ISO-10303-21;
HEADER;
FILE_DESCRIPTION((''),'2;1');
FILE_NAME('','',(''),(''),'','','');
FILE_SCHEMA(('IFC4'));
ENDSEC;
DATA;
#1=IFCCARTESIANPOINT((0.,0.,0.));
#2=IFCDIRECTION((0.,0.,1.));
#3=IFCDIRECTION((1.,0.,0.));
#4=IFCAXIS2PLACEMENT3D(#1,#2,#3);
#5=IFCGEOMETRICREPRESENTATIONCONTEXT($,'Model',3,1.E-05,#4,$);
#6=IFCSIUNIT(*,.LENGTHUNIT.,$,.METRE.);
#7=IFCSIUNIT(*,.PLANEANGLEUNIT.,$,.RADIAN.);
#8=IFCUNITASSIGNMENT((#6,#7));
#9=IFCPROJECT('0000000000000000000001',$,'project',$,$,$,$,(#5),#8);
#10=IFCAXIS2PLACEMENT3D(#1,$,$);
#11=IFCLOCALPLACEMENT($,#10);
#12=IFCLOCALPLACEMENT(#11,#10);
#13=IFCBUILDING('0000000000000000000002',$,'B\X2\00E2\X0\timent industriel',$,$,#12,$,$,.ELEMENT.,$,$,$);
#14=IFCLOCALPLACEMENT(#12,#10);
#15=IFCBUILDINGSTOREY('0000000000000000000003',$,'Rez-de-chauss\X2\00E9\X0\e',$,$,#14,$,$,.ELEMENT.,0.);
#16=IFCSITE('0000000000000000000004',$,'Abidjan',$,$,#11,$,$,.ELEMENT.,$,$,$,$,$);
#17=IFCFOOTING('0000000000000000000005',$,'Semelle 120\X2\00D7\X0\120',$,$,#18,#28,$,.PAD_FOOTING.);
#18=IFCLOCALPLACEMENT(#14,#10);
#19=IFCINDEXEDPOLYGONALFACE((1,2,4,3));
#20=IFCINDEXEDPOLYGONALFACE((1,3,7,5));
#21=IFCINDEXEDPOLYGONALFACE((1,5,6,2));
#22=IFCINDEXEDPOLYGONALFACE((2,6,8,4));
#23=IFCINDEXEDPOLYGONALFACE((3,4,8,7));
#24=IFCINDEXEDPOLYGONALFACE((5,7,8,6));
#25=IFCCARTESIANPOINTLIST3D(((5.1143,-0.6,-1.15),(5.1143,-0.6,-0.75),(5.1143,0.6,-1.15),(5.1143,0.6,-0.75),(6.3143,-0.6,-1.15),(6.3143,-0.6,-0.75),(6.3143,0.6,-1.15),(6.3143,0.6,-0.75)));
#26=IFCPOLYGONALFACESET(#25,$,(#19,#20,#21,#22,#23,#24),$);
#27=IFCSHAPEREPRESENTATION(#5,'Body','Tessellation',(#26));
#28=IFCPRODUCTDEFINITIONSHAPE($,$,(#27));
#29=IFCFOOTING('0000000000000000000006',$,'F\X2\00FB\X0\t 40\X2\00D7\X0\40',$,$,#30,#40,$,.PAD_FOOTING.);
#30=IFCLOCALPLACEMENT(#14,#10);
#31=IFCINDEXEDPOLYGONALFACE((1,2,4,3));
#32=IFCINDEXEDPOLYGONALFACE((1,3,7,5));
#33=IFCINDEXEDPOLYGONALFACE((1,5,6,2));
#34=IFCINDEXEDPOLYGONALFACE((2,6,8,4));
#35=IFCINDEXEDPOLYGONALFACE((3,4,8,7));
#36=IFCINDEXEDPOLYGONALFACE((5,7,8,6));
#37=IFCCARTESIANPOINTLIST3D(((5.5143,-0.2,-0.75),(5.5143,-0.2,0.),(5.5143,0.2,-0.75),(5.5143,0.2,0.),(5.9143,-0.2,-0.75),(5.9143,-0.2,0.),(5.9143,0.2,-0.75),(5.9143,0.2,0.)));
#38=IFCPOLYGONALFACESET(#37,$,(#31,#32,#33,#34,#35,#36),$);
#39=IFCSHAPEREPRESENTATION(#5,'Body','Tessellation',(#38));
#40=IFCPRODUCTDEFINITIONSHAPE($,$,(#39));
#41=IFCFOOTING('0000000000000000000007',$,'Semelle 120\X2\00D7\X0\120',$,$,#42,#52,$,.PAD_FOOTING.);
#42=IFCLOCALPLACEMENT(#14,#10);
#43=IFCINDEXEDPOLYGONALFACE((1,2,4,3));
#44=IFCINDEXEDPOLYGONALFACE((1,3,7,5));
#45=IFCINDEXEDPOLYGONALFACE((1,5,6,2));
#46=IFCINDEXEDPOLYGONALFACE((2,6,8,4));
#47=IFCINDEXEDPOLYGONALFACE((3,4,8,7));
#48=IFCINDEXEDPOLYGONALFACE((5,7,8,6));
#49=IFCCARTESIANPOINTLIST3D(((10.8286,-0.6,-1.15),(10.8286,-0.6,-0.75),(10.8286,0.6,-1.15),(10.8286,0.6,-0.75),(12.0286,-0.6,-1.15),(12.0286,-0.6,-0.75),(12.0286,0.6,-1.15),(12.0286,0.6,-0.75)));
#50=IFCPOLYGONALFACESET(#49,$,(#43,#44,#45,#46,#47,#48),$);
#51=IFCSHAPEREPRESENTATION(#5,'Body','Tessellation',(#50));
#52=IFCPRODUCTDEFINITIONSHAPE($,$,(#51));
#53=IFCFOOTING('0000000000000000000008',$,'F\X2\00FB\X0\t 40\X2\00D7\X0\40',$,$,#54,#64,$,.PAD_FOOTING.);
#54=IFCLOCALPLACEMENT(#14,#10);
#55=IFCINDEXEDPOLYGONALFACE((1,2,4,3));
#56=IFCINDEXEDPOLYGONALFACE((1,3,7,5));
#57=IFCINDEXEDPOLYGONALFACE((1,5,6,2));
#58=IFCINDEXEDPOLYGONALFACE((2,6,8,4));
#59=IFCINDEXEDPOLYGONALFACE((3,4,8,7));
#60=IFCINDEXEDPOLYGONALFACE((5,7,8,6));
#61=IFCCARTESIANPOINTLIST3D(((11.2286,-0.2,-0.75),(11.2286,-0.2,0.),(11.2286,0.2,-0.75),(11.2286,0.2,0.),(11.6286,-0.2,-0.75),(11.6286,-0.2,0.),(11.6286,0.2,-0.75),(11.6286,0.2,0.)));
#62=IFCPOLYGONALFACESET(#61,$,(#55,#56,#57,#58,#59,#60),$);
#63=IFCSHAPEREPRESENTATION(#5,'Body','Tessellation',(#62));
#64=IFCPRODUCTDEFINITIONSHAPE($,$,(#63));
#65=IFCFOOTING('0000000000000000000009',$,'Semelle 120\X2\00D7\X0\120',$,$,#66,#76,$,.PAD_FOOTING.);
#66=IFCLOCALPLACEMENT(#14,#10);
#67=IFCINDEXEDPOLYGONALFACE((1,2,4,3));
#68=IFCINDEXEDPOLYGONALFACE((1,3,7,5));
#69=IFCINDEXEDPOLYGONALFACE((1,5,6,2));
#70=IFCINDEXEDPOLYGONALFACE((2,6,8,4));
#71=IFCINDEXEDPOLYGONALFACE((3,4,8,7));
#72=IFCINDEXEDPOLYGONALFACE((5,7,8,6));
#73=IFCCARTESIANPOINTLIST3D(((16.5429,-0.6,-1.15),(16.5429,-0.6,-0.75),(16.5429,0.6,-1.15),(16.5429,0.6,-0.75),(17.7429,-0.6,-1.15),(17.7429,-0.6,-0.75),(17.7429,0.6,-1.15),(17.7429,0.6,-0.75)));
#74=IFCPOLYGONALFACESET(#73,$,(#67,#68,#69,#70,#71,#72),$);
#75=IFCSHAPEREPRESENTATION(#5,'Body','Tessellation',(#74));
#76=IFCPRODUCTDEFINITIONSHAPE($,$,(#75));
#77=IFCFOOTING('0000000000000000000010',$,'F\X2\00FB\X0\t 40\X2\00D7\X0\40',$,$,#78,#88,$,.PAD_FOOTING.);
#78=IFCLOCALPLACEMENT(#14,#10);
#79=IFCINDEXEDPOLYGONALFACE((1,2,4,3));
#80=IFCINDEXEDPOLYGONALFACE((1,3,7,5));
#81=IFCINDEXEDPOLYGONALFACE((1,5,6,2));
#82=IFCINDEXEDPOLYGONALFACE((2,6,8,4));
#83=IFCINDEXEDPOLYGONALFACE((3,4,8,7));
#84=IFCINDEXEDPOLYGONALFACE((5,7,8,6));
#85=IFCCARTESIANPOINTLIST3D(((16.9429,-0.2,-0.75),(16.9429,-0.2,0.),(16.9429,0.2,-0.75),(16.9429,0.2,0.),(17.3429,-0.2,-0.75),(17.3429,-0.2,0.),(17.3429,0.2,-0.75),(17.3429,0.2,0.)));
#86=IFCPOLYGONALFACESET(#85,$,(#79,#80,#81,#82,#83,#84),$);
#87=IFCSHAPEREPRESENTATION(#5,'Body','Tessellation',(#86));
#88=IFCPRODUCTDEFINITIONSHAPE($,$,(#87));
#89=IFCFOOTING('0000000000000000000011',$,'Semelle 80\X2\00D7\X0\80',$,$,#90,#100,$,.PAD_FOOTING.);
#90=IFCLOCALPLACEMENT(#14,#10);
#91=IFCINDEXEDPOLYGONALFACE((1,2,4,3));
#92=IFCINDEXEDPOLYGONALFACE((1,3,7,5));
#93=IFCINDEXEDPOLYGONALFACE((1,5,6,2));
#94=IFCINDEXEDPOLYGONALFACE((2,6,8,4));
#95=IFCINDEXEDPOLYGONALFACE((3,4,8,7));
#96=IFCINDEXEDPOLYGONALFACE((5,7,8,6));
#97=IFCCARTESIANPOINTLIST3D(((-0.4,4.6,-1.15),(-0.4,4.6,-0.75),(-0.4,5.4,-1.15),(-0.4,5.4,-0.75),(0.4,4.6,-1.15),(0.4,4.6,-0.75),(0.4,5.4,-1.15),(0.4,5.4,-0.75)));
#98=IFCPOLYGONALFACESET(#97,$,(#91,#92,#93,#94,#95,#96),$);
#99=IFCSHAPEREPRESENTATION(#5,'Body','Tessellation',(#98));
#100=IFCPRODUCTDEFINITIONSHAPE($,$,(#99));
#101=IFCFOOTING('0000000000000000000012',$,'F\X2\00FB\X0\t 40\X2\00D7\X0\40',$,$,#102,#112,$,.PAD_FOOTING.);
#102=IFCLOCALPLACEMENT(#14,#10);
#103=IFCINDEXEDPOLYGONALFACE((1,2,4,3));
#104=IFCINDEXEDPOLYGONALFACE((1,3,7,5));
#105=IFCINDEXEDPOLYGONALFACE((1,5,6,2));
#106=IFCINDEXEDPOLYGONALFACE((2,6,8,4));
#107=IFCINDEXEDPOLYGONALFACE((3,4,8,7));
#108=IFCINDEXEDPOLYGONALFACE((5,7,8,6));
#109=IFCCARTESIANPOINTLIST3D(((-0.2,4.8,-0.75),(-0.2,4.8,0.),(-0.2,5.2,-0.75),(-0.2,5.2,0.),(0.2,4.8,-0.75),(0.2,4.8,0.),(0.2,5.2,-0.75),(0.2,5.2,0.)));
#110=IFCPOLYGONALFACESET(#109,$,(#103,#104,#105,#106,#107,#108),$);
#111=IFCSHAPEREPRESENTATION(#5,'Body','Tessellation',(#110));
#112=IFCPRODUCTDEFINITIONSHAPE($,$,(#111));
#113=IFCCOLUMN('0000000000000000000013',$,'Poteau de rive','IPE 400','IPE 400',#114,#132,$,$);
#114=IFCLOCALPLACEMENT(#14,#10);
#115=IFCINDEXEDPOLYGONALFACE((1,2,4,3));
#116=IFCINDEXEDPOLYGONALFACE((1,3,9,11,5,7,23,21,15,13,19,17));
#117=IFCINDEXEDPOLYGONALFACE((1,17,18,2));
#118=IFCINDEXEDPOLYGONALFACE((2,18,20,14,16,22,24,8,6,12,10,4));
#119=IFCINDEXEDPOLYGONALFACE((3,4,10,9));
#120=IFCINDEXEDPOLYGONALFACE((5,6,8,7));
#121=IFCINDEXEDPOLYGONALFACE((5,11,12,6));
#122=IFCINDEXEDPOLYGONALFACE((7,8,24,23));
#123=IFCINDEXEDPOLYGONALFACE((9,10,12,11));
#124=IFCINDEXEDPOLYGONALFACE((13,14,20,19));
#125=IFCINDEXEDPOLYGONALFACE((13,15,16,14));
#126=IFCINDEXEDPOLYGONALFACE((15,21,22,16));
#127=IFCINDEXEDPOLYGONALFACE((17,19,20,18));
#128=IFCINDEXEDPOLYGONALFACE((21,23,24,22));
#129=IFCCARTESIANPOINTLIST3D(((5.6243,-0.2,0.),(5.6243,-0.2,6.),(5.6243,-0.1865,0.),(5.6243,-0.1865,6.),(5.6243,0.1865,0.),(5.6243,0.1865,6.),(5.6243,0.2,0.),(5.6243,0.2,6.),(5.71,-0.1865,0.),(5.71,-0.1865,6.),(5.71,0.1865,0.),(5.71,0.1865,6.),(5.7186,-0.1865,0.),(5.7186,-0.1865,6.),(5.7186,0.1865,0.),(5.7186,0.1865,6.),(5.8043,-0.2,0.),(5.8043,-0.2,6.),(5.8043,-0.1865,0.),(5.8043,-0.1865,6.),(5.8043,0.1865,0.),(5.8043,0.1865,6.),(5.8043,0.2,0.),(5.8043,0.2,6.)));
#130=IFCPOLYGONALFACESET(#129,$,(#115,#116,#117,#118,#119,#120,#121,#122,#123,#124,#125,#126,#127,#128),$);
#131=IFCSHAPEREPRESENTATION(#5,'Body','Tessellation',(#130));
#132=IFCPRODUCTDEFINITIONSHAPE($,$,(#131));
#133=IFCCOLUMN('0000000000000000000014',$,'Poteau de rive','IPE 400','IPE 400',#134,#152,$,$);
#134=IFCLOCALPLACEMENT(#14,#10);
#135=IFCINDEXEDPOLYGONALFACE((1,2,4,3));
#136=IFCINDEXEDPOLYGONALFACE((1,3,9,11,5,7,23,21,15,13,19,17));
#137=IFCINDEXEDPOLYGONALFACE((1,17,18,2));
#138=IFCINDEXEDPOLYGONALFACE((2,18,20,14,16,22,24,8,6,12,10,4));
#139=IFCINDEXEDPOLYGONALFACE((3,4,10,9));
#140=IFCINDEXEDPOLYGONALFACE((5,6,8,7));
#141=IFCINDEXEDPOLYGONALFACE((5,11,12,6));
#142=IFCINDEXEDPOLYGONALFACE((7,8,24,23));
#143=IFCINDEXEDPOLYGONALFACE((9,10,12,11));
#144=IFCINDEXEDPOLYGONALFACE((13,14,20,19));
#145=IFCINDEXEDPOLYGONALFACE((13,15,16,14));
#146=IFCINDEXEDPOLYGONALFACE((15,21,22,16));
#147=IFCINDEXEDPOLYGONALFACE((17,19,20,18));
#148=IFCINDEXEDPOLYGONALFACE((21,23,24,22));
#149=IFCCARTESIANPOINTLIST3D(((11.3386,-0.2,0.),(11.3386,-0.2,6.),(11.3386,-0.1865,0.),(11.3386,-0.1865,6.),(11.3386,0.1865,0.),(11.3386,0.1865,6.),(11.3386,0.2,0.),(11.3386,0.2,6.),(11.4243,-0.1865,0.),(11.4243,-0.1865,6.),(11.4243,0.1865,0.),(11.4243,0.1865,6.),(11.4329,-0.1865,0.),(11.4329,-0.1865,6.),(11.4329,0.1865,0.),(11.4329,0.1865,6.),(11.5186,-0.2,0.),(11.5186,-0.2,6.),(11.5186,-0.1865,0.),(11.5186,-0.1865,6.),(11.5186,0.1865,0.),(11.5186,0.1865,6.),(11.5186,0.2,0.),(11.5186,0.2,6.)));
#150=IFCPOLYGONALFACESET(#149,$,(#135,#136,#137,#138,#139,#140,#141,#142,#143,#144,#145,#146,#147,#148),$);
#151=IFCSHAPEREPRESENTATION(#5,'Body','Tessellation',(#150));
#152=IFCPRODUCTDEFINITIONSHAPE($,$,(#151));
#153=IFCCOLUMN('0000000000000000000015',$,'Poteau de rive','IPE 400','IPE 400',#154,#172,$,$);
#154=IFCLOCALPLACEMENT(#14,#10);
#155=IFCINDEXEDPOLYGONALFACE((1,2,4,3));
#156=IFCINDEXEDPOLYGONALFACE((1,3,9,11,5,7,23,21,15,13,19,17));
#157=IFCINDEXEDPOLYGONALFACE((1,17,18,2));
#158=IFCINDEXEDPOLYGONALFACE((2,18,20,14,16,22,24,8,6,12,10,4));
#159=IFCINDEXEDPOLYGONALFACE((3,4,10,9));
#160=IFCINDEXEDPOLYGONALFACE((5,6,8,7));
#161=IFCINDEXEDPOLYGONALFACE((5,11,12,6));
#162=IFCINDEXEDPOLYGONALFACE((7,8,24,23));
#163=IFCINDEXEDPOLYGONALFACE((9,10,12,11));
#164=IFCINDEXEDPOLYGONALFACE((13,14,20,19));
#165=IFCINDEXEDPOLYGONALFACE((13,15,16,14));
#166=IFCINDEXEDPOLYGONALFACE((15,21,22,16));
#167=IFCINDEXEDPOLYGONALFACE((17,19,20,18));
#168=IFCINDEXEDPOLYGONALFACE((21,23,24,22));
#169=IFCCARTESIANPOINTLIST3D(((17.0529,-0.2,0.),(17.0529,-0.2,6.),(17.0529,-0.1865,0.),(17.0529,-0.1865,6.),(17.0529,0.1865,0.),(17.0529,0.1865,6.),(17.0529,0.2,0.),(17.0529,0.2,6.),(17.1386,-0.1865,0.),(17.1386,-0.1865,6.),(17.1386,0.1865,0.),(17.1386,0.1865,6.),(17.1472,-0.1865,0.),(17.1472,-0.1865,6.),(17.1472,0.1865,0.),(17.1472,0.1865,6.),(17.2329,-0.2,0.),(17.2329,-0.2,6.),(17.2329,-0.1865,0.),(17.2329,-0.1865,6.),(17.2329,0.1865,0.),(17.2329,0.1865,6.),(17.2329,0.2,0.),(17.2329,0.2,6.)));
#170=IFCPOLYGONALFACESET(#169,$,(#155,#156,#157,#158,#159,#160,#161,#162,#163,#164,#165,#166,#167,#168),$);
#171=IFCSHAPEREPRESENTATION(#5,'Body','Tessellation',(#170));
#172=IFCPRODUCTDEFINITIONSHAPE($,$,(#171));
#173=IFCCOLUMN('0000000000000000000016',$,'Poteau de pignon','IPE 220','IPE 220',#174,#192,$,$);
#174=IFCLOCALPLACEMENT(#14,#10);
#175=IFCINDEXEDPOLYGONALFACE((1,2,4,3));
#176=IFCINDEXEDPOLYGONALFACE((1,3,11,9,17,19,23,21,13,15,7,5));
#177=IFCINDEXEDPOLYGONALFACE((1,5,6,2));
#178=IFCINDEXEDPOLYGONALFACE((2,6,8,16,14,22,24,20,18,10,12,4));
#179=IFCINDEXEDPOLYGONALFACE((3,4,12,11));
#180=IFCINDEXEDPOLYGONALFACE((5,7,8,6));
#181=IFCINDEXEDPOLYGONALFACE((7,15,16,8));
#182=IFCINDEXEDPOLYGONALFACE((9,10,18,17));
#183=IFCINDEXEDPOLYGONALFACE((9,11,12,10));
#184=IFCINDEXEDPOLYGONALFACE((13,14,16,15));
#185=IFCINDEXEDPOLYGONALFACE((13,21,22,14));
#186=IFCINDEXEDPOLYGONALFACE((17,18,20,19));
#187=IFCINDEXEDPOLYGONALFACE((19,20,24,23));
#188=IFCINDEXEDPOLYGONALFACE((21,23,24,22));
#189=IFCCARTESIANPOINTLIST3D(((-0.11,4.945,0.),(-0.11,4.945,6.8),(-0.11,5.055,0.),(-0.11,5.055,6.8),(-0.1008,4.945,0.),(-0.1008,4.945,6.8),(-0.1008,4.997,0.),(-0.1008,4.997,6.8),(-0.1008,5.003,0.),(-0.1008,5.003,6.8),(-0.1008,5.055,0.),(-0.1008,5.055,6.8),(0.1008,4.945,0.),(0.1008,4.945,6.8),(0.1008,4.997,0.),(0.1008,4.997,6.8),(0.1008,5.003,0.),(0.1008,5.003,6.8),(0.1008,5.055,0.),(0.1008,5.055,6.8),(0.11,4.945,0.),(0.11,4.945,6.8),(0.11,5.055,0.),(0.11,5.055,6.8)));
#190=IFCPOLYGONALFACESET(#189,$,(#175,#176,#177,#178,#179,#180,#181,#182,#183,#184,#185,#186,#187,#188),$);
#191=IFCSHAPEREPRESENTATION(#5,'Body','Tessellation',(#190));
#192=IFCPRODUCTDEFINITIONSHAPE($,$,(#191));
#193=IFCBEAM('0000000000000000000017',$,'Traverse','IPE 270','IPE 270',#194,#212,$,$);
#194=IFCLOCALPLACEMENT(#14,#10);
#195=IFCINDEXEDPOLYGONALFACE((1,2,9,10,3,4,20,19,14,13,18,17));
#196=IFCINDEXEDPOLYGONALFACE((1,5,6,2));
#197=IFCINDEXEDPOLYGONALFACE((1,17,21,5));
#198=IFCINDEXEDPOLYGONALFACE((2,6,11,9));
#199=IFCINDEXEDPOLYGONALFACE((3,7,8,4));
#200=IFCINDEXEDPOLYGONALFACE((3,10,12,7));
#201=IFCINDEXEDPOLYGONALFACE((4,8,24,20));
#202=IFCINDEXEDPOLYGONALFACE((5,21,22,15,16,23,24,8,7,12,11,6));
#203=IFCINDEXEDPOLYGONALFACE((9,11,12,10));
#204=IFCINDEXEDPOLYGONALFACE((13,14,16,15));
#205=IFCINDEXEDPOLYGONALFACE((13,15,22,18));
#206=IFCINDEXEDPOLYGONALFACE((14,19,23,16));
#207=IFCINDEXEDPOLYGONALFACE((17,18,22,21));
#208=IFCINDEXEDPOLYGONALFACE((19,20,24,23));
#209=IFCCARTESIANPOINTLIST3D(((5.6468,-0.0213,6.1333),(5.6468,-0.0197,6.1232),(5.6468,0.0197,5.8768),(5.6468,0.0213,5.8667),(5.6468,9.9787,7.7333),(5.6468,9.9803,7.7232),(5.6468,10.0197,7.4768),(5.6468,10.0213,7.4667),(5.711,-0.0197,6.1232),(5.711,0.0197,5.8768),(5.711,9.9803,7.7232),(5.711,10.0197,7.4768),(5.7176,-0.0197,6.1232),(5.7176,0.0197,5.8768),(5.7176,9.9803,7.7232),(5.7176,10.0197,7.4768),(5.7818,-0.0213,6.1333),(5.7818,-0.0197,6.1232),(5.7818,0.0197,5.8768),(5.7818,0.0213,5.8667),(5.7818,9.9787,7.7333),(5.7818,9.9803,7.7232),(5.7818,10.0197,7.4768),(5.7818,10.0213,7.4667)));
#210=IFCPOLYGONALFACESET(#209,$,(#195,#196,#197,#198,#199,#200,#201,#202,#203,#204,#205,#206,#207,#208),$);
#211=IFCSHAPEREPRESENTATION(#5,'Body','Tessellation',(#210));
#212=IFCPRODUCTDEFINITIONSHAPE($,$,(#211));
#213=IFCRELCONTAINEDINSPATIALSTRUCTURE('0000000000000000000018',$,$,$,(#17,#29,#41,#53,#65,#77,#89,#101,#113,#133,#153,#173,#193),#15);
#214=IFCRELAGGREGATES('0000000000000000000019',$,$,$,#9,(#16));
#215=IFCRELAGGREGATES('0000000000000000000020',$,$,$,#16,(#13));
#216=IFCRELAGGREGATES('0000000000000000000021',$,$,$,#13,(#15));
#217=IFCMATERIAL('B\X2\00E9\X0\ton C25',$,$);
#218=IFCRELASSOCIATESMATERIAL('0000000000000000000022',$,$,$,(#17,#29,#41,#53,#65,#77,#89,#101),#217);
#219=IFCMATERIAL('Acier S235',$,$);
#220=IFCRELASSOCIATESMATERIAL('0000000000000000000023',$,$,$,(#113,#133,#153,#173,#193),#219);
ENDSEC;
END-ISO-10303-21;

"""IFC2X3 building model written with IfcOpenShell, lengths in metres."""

from ifc_helpers import new_model, si_unit, frame, origin, origin_with_axes, origin_2d, place, context, project, spatial, rectangle, i_section, extrude, material, element, save


model = new_model("IFC2X3")

# Units and contexts
model_context = context("Model", 3, precision=1e-05, world=origin_with_axes())
ifc_project = project(units=[si_unit("LENGTHUNIT", "METRE"), si_unit("PLANEANGLEUNIT", "RADIAN")], contexts=[model_context])

# Site, building, storey
site_placement = place(None, origin())
site = spatial("IfcSite", under=ifc_project, at=site_placement, Name="Abidjan", CompositionType="ELEMENT")
building_placement = place(site_placement, origin())
building = spatial("IfcBuilding", under=site, at=building_placement, Name="Bâtiment industriel", CompositionType="ELEMENT")
storey_placement = place(building_placement, origin())
storey = spatial("IfcBuildingStorey", under=building, at=storey_placement, Name="Rez-de-chaussée", CompositionType="ELEMENT", Elevation=0.0)

# Footings
ifc_material_1 = material(Name="Béton C25")
footing_1_placement = place(storey_placement, frame((5.7143, 0.0, -1.15), z_axis=(0.0, 0.0, 1.0), x_axis=(1.0, 0.0, 0.0)))
element("IfcFooting", 1, at=footing_1_placement, inside=storey, material=ifc_material_1, Name="Semelle 120×120", PredefinedType="PAD_FOOTING", context=model_context, shape_type="SweptSolid", body=[
    extrude(rectangle(XDim=1.2, YDim=1.2, at=origin_2d()), origin(), (0.0, 0.0, 1.0), 0.4),
])
footing_2_placement = place(storey_placement, frame((5.7143, 0.0, -0.75), z_axis=(0.0, 0.0, 1.0), x_axis=(1.0, 0.0, 0.0)))
element("IfcFooting", 2, at=footing_2_placement, inside=storey, material=ifc_material_1, Name="Fût 40×40", PredefinedType="PAD_FOOTING", context=model_context, shape_type="SweptSolid", body=[
    extrude(rectangle(XDim=0.4, YDim=0.4, at=origin_2d()), origin(), (0.0, 0.0, 1.0), 0.75),
])
footing_3_placement = place(storey_placement, frame((11.4286, 0.0, -1.15), z_axis=(0.0, 0.0, 1.0), x_axis=(1.0, 0.0, 0.0)))
element("IfcFooting", 3, at=footing_3_placement, inside=storey, material=ifc_material_1, Name="Semelle 120×120", PredefinedType="PAD_FOOTING", context=model_context, shape_type="SweptSolid", body=[
    extrude(rectangle(XDim=1.2, YDim=1.2, at=origin_2d()), origin(), (0.0, 0.0, 1.0), 0.4),
])
footing_4_placement = place(storey_placement, frame((11.4286, 0.0, -0.75), z_axis=(0.0, 0.0, 1.0), x_axis=(1.0, 0.0, 0.0)))
element("IfcFooting", 4, at=footing_4_placement, inside=storey, material=ifc_material_1, Name="Fût 40×40", PredefinedType="PAD_FOOTING", context=model_context, shape_type="SweptSolid", body=[
    extrude(rectangle(XDim=0.4, YDim=0.4, at=origin_2d()), origin(), (0.0, 0.0, 1.0), 0.75),
])
footing_5_placement = place(storey_placement, frame((17.1429, 0.0, -1.15), z_axis=(0.0, 0.0, 1.0), x_axis=(1.0, 0.0, 0.0)))
element("IfcFooting", 5, at=footing_5_placement, inside=storey, material=ifc_material_1, Name="Semelle 120×120", PredefinedType="PAD_FOOTING", context=model_context, shape_type="SweptSolid", body=[
    extrude(rectangle(XDim=1.2, YDim=1.2, at=origin_2d()), origin(), (0.0, 0.0, 1.0), 0.4),
])
footing_6_placement = place(storey_placement, frame((17.1429, 0.0, -0.75), z_axis=(0.0, 0.0, 1.0), x_axis=(1.0, 0.0, 0.0)))
element("IfcFooting", 6, at=footing_6_placement, inside=storey, material=ifc_material_1, Name="Fût 40×40", PredefinedType="PAD_FOOTING", context=model_context, shape_type="SweptSolid", body=[
    extrude(rectangle(XDim=0.4, YDim=0.4, at=origin_2d()), origin(), (0.0, 0.0, 1.0), 0.75),
])
footing_7_placement = place(storey_placement, frame((0.0, 5.0, -1.15), z_axis=(0.0, 0.0, 1.0), x_axis=(1.0, 0.0, 0.0)))
element("IfcFooting", 7, at=footing_7_placement, inside=storey, material=ifc_material_1, Name="Semelle 80×80", PredefinedType="PAD_FOOTING", context=model_context, shape_type="SweptSolid", body=[
    extrude(rectangle(XDim=0.8, YDim=0.8, at=origin_2d()), origin(), (0.0, 0.0, 1.0), 0.4),
])
footing_8_placement = place(storey_placement, frame((0.0, 5.0, -0.75), z_axis=(0.0, 0.0, 1.0), x_axis=(1.0, 0.0, 0.0)))
element("IfcFooting", 8, at=footing_8_placement, inside=storey, material=ifc_material_1, Name="Fût 40×40", PredefinedType="PAD_FOOTING", context=model_context, shape_type="SweptSolid", body=[
    extrude(rectangle(XDim=0.4, YDim=0.4, at=origin_2d()), origin(), (0.0, 0.0, 1.0), 0.75),
])

# Columns
ifc_material_2 = material(Name="Acier S235")
for number, where, z_axis, x_axis, name in (
    (9, (5.7143, 0.0, 0.0), (0.0, 0.0, 1.0), (1.0, 0.0, 0.0), "Poteau de rive"),
    (10, (11.4286, 0.0, 0.0), (0.0, 0.0, 1.0), (1.0, 0.0, 0.0), "Poteau de rive"),
    (11, (17.1429, 0.0, 0.0), (0.0, 0.0, 1.0), (1.0, 0.0, 0.0), "Poteau de rive"),
):
    element("IfcColumn", number, at=place(storey_placement, frame(where, z_axis=z_axis, x_axis=x_axis)), inside=storey, material=ifc_material_2, Name=name, Description="IPE 400", ObjectType="IPE 400", context=model_context, shape_type="SweptSolid", body=[
        extrude(i_section(OverallWidth=0.18, OverallDepth=0.4, WebThickness=0.0086, FlangeThickness=0.0135, at=origin_2d()), origin(), (0.0, 0.0, 1.0), 6.0),
    ])
column_placement = place(storey_placement, frame((0.0, 5.0, 0.0), z_axis=(0.0, 0.0, 1.0), x_axis=(0.0, 1.0, 0.0)))
element("IfcColumn", 12, at=column_placement, inside=storey, material=ifc_material_2, Name="Poteau de pignon", Description="IPE 220", ObjectType="IPE 220", context=model_context, shape_type="SweptSolid", body=[
    extrude(i_section(OverallWidth=0.11, OverallDepth=0.22, WebThickness=0.0059, FlangeThickness=0.0092, at=origin_2d()), origin(), (0.0, 0.0, 1.0), 6.8),
])

# Beam
beam_1_placement = place(storey_placement, frame((5.7143, 0.0, 6.0), z_axis=(0.0, 0.98744, 0.15799), x_axis=(1.0, 0.0, 0.0)))
element("IfcBeam", 13, at=beam_1_placement, inside=storey, material=ifc_material_2, Name="Traverse", Description="IPE 270", ObjectType="IPE 270", context=model_context, shape_type="SweptSolid", body=[
    extrude(i_section(OverallWidth=0.135, OverallDepth=0.27, WebThickness=0.0066, FlangeThickness=0.0102, at=origin_2d()), origin(), (0.0, 0.0, 1.0), 10.1272),
])

save(model, "model.ifc")
